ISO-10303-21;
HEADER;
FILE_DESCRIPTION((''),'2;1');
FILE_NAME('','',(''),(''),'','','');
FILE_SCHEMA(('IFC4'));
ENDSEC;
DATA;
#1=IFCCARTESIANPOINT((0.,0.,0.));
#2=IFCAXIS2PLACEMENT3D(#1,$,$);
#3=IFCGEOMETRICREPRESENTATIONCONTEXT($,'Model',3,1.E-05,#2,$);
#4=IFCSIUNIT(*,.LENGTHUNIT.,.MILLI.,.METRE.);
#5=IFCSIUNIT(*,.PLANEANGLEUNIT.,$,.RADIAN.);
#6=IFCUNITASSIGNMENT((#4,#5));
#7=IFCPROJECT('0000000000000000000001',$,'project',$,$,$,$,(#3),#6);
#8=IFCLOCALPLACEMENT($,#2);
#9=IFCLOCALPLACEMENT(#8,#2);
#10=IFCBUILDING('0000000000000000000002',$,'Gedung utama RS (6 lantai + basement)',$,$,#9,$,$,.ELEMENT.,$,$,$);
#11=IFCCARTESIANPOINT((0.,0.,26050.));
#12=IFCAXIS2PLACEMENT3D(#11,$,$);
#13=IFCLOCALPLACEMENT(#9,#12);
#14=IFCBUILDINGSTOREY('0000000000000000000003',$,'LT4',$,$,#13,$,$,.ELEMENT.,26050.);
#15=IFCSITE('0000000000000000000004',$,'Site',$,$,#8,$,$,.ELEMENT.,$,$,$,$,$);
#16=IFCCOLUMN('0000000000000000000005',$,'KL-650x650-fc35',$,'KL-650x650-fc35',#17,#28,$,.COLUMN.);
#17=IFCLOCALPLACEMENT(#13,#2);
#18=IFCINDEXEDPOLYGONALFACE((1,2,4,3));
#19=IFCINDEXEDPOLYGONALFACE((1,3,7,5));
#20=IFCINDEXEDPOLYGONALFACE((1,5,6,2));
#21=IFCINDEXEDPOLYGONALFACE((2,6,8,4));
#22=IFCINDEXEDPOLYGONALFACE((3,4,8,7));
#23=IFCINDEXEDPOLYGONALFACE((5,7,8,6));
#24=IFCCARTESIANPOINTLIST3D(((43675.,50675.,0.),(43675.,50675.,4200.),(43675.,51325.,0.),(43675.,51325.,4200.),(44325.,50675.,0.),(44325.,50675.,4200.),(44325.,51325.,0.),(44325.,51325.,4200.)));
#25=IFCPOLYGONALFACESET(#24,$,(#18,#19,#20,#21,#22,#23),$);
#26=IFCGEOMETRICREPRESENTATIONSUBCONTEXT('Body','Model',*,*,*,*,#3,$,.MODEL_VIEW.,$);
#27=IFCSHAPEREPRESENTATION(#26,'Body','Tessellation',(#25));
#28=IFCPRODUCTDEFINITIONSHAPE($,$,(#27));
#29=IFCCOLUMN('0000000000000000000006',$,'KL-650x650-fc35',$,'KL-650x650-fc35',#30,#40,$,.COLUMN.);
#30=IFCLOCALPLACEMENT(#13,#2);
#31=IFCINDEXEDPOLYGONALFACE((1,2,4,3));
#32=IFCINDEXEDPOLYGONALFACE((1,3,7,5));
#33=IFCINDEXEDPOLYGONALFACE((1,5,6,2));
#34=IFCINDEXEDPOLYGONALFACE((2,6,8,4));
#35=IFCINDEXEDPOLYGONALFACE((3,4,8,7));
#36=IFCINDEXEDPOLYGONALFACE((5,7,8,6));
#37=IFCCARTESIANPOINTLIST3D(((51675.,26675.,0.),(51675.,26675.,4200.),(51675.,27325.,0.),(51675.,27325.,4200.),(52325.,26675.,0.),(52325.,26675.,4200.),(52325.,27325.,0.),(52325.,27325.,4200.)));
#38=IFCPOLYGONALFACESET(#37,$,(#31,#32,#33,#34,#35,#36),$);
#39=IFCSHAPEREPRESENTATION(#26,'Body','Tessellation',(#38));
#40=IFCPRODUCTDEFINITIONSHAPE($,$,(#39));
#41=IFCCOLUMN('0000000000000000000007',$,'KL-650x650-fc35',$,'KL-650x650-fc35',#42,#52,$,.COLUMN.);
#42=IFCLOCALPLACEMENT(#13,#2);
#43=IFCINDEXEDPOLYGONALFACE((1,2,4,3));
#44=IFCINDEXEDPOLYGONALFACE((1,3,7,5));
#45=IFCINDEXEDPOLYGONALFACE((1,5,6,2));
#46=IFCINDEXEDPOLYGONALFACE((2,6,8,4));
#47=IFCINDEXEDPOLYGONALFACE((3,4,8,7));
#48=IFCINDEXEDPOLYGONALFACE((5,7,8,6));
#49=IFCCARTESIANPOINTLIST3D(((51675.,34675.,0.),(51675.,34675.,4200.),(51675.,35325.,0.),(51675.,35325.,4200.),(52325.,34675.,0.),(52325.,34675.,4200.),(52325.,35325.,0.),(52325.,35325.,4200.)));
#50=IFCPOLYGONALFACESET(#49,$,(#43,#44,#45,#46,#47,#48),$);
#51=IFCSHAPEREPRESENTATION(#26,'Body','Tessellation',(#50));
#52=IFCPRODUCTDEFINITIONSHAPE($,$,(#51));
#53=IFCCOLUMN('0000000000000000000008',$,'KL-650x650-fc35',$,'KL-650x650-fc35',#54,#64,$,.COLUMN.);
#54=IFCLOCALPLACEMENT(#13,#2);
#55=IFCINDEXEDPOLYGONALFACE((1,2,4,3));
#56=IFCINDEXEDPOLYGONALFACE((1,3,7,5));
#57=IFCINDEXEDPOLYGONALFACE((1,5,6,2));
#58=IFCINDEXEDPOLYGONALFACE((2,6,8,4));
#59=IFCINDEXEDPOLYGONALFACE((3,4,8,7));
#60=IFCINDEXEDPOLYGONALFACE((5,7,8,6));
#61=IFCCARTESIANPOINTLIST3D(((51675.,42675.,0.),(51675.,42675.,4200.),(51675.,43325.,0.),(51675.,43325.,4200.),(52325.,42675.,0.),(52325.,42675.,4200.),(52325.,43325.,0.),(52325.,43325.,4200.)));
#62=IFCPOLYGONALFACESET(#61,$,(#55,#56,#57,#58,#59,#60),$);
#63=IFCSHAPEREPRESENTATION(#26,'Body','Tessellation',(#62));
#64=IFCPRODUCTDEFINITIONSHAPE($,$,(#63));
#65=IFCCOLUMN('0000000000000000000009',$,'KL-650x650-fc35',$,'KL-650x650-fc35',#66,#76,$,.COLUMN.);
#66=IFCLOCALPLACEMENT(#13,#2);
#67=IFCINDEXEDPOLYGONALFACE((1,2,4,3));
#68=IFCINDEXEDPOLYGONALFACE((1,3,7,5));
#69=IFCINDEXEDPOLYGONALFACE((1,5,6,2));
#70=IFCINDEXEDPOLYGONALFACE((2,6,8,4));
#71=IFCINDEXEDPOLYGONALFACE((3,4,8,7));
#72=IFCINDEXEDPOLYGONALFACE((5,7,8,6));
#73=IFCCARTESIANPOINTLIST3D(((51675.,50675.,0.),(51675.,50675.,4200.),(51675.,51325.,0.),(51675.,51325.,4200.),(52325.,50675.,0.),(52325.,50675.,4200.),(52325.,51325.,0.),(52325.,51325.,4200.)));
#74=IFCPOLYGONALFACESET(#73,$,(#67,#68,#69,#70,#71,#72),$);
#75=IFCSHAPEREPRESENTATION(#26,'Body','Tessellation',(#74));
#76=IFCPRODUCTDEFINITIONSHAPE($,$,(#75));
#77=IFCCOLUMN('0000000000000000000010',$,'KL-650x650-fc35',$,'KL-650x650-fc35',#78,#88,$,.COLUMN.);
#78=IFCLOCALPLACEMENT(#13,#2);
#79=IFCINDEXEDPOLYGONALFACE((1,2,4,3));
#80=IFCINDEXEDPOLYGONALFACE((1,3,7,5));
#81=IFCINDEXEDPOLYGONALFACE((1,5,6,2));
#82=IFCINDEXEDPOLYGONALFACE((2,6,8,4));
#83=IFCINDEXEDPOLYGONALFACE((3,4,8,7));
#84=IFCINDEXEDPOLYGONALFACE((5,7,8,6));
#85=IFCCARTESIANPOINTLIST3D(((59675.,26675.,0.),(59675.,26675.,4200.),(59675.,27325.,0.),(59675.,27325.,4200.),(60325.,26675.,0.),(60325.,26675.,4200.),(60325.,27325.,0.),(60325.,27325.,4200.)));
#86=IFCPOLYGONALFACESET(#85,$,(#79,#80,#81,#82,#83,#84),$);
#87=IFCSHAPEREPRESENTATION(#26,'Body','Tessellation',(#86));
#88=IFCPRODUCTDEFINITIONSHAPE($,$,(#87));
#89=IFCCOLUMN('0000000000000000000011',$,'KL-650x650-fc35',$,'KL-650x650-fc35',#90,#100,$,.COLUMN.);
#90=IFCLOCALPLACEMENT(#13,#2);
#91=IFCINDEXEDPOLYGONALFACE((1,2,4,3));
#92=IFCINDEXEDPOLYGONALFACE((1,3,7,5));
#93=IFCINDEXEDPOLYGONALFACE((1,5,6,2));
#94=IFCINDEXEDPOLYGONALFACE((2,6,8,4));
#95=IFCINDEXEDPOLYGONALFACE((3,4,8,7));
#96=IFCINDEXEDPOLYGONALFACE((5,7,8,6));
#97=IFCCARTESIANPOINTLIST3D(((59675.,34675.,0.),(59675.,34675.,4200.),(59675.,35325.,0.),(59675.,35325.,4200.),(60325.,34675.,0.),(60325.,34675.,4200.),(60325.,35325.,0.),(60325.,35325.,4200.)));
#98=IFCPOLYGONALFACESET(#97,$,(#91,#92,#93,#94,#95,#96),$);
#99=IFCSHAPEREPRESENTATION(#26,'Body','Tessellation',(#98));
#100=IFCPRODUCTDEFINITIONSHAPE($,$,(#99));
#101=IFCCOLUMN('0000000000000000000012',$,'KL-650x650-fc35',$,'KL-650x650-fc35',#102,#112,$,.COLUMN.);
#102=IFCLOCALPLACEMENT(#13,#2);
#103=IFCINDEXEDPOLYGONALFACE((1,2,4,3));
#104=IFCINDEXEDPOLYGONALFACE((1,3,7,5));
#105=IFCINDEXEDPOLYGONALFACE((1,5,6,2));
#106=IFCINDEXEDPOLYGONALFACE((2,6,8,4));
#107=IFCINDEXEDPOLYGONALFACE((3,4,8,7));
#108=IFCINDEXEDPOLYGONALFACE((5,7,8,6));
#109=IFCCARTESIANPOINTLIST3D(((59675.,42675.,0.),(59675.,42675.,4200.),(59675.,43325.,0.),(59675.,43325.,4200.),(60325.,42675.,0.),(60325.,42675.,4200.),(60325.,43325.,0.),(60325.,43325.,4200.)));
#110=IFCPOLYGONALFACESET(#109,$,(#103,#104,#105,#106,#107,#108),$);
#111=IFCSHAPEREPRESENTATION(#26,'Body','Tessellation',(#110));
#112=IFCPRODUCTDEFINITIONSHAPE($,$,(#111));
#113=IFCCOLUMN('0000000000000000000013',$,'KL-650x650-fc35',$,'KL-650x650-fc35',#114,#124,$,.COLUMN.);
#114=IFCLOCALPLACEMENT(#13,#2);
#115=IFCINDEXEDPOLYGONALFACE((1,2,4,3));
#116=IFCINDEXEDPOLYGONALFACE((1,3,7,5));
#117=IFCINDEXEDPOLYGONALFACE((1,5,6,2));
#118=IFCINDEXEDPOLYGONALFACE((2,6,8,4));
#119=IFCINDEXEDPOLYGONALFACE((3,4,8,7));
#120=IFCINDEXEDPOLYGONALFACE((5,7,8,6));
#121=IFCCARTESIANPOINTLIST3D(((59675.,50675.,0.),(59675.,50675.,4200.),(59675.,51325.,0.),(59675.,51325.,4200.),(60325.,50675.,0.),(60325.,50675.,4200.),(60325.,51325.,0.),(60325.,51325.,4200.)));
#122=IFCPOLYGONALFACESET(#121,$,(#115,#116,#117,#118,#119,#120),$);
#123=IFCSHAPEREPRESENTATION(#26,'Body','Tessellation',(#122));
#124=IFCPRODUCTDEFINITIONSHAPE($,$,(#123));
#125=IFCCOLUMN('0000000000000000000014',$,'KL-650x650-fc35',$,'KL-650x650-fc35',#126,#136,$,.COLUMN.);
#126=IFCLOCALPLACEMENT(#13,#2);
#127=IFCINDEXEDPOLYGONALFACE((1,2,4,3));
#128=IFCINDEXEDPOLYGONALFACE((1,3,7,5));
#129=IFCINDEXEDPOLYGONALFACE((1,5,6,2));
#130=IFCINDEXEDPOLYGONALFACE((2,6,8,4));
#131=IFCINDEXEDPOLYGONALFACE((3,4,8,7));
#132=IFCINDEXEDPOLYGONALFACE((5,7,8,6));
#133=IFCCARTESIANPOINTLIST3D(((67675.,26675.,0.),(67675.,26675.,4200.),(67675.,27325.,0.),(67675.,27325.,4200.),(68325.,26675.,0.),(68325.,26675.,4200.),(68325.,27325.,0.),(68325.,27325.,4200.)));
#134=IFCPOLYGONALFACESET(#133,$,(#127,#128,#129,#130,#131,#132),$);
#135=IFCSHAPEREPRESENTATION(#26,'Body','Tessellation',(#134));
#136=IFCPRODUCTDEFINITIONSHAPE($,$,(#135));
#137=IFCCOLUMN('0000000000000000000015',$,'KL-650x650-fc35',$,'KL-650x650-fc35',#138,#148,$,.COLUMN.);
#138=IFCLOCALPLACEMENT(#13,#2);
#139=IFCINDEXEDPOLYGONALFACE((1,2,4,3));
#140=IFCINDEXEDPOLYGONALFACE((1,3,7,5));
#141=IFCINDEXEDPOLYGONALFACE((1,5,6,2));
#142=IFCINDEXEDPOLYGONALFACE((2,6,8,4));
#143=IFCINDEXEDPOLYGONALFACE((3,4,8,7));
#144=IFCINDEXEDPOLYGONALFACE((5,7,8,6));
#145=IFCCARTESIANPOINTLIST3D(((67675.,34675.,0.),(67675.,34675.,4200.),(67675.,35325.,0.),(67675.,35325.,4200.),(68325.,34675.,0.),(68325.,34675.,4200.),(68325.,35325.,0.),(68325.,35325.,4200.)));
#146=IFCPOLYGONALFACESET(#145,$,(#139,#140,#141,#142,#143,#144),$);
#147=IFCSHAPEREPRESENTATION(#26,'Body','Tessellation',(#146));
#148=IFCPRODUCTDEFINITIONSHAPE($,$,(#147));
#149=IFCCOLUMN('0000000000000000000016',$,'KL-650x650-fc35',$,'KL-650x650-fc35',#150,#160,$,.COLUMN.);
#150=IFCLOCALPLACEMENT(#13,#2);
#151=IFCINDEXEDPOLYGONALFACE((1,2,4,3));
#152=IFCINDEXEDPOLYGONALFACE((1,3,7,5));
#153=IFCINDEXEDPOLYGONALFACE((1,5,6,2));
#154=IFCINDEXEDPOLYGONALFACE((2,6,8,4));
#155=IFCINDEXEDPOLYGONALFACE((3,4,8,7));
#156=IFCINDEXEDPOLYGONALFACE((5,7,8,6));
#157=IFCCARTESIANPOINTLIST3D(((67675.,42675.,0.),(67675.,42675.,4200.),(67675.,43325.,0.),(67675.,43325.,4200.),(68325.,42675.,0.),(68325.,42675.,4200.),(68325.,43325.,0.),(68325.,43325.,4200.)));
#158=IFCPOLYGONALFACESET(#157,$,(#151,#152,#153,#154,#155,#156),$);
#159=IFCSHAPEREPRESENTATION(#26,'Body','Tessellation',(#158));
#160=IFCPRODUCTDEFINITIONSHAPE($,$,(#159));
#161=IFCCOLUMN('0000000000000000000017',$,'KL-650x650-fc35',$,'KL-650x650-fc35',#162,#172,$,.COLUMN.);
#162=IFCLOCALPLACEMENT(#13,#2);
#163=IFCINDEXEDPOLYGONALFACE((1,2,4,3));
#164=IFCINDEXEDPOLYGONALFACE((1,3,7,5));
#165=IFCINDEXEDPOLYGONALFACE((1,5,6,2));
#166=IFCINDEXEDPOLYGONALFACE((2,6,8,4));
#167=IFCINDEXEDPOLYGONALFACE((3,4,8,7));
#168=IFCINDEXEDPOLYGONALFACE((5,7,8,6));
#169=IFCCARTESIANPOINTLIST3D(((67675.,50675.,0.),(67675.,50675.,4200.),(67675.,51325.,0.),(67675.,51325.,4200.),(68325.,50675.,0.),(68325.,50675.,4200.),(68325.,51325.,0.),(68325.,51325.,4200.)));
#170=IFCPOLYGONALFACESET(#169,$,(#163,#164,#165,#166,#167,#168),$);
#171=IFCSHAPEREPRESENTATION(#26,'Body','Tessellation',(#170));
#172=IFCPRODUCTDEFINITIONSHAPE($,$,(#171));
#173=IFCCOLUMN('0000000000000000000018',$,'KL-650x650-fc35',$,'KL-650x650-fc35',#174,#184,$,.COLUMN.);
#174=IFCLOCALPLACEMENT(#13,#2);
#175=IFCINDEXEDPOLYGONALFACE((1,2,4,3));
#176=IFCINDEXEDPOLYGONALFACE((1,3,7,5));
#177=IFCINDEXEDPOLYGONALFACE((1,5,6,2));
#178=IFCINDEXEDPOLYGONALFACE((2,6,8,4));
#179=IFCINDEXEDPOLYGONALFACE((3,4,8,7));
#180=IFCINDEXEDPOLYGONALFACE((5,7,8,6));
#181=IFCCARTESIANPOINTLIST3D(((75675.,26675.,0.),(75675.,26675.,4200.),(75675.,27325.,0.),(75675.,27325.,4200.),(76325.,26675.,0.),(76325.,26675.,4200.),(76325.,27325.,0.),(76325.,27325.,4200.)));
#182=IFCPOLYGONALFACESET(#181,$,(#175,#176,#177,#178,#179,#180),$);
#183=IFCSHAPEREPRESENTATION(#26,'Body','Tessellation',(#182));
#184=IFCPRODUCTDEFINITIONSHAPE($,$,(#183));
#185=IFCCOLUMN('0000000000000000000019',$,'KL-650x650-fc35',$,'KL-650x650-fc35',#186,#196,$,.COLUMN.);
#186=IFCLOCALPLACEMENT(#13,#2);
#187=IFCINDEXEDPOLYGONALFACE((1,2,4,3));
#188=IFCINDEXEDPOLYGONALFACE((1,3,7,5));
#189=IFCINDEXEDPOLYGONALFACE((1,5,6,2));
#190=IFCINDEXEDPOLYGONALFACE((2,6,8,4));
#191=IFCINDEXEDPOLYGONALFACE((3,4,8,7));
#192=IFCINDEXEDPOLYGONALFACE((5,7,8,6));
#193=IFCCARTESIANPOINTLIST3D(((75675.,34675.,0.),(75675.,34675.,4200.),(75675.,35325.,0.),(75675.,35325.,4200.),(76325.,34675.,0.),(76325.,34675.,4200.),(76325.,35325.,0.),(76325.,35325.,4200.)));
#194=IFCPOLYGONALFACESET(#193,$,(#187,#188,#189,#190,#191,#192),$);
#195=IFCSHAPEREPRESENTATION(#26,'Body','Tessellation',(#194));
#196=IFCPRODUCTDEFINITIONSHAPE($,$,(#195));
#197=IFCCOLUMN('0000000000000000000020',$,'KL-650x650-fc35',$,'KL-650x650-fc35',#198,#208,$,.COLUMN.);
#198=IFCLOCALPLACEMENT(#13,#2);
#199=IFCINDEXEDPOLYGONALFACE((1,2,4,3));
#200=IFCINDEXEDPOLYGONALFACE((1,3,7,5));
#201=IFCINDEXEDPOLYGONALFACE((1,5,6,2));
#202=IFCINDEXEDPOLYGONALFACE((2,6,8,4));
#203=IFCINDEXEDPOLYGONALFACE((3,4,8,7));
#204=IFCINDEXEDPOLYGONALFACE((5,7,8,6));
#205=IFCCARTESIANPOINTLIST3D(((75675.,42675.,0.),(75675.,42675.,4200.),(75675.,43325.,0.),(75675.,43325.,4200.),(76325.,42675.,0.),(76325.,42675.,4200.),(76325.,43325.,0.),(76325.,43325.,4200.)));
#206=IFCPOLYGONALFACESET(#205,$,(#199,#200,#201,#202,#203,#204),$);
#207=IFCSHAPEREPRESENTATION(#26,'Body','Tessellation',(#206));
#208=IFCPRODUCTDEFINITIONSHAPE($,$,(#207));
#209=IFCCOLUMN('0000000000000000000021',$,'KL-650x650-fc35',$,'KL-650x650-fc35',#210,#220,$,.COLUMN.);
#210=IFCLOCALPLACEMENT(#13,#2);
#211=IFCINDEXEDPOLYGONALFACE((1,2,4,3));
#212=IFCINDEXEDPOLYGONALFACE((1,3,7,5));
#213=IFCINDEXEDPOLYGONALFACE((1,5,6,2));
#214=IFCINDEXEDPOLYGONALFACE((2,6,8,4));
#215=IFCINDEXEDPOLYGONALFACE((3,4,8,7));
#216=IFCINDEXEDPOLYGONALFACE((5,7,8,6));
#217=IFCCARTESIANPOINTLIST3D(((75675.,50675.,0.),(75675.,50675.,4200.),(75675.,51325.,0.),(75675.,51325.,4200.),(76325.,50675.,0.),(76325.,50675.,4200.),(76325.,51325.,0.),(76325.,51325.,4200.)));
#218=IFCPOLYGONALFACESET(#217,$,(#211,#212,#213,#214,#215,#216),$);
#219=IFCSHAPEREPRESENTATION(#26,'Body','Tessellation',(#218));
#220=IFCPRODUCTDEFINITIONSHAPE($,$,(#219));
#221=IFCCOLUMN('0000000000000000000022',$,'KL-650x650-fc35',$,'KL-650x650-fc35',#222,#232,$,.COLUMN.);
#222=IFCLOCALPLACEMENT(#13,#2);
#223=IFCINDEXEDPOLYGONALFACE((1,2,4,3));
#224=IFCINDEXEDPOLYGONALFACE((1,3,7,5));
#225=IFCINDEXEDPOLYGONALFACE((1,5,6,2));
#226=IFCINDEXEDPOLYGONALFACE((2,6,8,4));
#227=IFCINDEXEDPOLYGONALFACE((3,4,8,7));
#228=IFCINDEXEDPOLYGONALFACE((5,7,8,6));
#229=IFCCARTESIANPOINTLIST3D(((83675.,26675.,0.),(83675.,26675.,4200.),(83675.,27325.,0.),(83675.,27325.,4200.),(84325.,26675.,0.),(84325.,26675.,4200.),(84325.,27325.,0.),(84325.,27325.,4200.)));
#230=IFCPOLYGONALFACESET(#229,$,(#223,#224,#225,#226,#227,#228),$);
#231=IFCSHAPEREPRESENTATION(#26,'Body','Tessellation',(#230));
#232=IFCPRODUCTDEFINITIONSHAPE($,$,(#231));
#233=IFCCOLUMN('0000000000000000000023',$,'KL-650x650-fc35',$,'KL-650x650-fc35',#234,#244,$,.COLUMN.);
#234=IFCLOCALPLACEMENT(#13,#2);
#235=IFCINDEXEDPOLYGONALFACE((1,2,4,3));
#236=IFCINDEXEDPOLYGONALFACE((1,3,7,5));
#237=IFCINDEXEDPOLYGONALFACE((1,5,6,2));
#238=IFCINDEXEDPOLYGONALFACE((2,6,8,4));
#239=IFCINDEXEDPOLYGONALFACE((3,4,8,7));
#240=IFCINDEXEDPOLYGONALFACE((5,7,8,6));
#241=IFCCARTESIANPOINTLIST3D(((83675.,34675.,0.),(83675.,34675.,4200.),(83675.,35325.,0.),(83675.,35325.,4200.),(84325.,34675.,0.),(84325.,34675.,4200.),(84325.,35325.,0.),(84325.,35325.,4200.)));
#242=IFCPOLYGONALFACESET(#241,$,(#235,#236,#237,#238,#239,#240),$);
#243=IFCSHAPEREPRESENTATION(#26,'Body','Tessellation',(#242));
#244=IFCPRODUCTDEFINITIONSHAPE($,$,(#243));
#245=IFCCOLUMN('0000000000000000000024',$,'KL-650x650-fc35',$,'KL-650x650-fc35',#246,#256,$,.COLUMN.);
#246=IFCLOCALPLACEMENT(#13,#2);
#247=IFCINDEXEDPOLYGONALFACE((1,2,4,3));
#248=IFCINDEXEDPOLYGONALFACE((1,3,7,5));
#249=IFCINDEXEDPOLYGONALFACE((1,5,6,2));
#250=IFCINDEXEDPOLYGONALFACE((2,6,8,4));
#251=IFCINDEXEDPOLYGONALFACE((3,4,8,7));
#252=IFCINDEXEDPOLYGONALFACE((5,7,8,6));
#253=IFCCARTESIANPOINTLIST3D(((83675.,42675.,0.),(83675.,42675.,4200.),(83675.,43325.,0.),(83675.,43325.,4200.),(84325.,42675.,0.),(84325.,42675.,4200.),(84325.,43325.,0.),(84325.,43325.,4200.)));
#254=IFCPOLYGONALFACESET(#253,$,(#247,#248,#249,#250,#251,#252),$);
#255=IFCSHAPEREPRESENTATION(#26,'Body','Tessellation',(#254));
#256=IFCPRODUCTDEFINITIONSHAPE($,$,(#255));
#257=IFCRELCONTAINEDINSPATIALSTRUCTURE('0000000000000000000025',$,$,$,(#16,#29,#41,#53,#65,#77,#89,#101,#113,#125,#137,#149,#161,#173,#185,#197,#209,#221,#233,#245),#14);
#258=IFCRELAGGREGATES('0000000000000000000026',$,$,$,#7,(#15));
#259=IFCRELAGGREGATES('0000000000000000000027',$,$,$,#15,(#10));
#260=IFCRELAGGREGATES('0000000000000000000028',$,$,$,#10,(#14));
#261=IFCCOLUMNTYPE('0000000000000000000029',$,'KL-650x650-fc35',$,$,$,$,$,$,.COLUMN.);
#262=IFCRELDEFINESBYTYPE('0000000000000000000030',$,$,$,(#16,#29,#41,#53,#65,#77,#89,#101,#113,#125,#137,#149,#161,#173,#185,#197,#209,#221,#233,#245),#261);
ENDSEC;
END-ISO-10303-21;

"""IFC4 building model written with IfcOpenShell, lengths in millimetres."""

from ifc_helpers import new_model, si_unit, frame, origin, origin_2d, place, context, subcontext, project, spatial, rectangle, extrude, material_profile, profile_set, profile_usage, type_object, element, save


model = new_model("IFC4")

# Units and contexts
model_context = context("Model", 3, precision=1e-05, world=origin())
body_context = subcontext(model_context, "Body", "Model", "MODEL_VIEW")
ifc_project = project(units=[si_unit("LENGTHUNIT", "METRE", prefix="MILLI"), si_unit("PLANEANGLEUNIT", "RADIAN")], contexts=[model_context])

# Site, building, storey
site_placement = place(None, origin())
site = spatial("IfcSite", under=ifc_project, at=site_placement, Name="Site", CompositionType="ELEMENT")
building_placement = place(site_placement, origin())
building = spatial("IfcBuilding", under=site, at=building_placement, Name="Gedung utama RS (6 lantai + basement)", CompositionType="ELEMENT")
storey_placement = place(building_placement, frame((0.0, 0.0, 26050.0)))
storey = spatial("IfcBuildingStorey", under=building, at=storey_placement, Name="LT4", CompositionType="ELEMENT", Elevation=26050.0)

# Columns
ifc_material_profile_1 = material_profile(None, rectangle(XDim=650.0, YDim=650.0, at=origin_2d()), Name="KL-650x650-fc35")
ifc_profile_set_1 = profile_set([ifc_material_profile_1], Name="KL-650x650-fc35")
ifc_profile_usage_1 = profile_usage(ifc_profile_set_1, cardinal=5)
column_type = type_object("IfcColumnType", Name="KL-650x650-fc35", PredefinedType="COLUMN", material=ifc_profile_set_1)
for number, where, z_axis, x_axis, name in (
    (1, (44000.0, 51000.0, 0.0), (0.0, 0.0, 1.0), (1.0, 0.0, 0.0), "KL-650x650-fc35"),
    (2, (52000.0, 27000.0, 0.0), (0.0, 0.0, 1.0), (1.0, 0.0, 0.0), "KL-650x650-fc35"),
    (3, (52000.0, 35000.0, 0.0), (0.0, 0.0, 1.0), (1.0, 0.0, 0.0), "KL-650x650-fc35"),
    (4, (52000.0, 43000.0, 0.0), (0.0, 0.0, 1.0), (1.0, 0.0, 0.0), "KL-650x650-fc35"),
    (5, (52000.0, 51000.0, 0.0), (0.0, 0.0, 1.0), (1.0, 0.0, 0.0), "KL-650x650-fc35"),
    (6, (60000.0, 27000.0, 0.0), (0.0, 0.0, 1.0), (1.0, 0.0, 0.0), "KL-650x650-fc35"),
    (7, (60000.0, 35000.0, 0.0), (0.0, 0.0, 1.0), (1.0, 0.0, 0.0), "KL-650x650-fc35"),
    (8, (60000.0, 43000.0, 0.0), (0.0, 0.0, 1.0), (1.0, 0.0, 0.0), "KL-650x650-fc35"),
    (9, (60000.0, 51000.0, 0.0), (0.0, 0.0, 1.0), (1.0, 0.0, 0.0), "KL-650x650-fc35"),
    (10, (68000.0, 27000.0, 0.0), (0.0, 0.0, 1.0), (1.0, 0.0, 0.0), "KL-650x650-fc35"),
    (11, (68000.0, 35000.0, 0.0), (0.0, 0.0, 1.0), (1.0, 0.0, 0.0), "KL-650x650-fc35"),
    (12, (68000.0, 43000.0, 0.0), (0.0, 0.0, 1.0), (1.0, 0.0, 0.0), "KL-650x650-fc35"),
    (13, (68000.0, 51000.0, 0.0), (0.0, 0.0, 1.0), (1.0, 0.0, 0.0), "KL-650x650-fc35"),
    (14, (76000.0, 27000.0, 0.0), (0.0, 0.0, 1.0), (1.0, 0.0, 0.0), "KL-650x650-fc35"),
    (15, (76000.0, 35000.0, 0.0), (0.0, 0.0, 1.0), (1.0, 0.0, 0.0), "KL-650x650-fc35"),
    (16, (76000.0, 43000.0, 0.0), (0.0, 0.0, 1.0), (1.0, 0.0, 0.0), "KL-650x650-fc35"),
    (17, (76000.0, 51000.0, 0.0), (0.0, 0.0, 1.0), (1.0, 0.0, 0.0), "KL-650x650-fc35"),
    (18, (84000.0, 27000.0, 0.0), (0.0, 0.0, 1.0), (1.0, 0.0, 0.0), "KL-650x650-fc35"),
    (19, (84000.0, 35000.0, 0.0), (0.0, 0.0, 1.0), (1.0, 0.0, 0.0), "KL-650x650-fc35"),
    (20, (84000.0, 43000.0, 0.0), (0.0, 0.0, 1.0), (1.0, 0.0, 0.0), "KL-650x650-fc35"),
):
    element("IfcColumn", number, at=place(storey_placement, frame(where, z_axis=z_axis, x_axis=x_axis)), inside=storey, type_object=column_type, material=ifc_profile_usage_1, Name=name, ObjectType="KL-650x650-fc35", PredefinedType="COLUMN", context=body_context, shape_type="SweptSolid", body=[
        extrude(rectangle(XDim=650.0, YDim=650.0, at=origin_2d()), origin(), (0.0, 0.0, 1.0), 4200.0),
    ])

save(model, "model.ifc")
